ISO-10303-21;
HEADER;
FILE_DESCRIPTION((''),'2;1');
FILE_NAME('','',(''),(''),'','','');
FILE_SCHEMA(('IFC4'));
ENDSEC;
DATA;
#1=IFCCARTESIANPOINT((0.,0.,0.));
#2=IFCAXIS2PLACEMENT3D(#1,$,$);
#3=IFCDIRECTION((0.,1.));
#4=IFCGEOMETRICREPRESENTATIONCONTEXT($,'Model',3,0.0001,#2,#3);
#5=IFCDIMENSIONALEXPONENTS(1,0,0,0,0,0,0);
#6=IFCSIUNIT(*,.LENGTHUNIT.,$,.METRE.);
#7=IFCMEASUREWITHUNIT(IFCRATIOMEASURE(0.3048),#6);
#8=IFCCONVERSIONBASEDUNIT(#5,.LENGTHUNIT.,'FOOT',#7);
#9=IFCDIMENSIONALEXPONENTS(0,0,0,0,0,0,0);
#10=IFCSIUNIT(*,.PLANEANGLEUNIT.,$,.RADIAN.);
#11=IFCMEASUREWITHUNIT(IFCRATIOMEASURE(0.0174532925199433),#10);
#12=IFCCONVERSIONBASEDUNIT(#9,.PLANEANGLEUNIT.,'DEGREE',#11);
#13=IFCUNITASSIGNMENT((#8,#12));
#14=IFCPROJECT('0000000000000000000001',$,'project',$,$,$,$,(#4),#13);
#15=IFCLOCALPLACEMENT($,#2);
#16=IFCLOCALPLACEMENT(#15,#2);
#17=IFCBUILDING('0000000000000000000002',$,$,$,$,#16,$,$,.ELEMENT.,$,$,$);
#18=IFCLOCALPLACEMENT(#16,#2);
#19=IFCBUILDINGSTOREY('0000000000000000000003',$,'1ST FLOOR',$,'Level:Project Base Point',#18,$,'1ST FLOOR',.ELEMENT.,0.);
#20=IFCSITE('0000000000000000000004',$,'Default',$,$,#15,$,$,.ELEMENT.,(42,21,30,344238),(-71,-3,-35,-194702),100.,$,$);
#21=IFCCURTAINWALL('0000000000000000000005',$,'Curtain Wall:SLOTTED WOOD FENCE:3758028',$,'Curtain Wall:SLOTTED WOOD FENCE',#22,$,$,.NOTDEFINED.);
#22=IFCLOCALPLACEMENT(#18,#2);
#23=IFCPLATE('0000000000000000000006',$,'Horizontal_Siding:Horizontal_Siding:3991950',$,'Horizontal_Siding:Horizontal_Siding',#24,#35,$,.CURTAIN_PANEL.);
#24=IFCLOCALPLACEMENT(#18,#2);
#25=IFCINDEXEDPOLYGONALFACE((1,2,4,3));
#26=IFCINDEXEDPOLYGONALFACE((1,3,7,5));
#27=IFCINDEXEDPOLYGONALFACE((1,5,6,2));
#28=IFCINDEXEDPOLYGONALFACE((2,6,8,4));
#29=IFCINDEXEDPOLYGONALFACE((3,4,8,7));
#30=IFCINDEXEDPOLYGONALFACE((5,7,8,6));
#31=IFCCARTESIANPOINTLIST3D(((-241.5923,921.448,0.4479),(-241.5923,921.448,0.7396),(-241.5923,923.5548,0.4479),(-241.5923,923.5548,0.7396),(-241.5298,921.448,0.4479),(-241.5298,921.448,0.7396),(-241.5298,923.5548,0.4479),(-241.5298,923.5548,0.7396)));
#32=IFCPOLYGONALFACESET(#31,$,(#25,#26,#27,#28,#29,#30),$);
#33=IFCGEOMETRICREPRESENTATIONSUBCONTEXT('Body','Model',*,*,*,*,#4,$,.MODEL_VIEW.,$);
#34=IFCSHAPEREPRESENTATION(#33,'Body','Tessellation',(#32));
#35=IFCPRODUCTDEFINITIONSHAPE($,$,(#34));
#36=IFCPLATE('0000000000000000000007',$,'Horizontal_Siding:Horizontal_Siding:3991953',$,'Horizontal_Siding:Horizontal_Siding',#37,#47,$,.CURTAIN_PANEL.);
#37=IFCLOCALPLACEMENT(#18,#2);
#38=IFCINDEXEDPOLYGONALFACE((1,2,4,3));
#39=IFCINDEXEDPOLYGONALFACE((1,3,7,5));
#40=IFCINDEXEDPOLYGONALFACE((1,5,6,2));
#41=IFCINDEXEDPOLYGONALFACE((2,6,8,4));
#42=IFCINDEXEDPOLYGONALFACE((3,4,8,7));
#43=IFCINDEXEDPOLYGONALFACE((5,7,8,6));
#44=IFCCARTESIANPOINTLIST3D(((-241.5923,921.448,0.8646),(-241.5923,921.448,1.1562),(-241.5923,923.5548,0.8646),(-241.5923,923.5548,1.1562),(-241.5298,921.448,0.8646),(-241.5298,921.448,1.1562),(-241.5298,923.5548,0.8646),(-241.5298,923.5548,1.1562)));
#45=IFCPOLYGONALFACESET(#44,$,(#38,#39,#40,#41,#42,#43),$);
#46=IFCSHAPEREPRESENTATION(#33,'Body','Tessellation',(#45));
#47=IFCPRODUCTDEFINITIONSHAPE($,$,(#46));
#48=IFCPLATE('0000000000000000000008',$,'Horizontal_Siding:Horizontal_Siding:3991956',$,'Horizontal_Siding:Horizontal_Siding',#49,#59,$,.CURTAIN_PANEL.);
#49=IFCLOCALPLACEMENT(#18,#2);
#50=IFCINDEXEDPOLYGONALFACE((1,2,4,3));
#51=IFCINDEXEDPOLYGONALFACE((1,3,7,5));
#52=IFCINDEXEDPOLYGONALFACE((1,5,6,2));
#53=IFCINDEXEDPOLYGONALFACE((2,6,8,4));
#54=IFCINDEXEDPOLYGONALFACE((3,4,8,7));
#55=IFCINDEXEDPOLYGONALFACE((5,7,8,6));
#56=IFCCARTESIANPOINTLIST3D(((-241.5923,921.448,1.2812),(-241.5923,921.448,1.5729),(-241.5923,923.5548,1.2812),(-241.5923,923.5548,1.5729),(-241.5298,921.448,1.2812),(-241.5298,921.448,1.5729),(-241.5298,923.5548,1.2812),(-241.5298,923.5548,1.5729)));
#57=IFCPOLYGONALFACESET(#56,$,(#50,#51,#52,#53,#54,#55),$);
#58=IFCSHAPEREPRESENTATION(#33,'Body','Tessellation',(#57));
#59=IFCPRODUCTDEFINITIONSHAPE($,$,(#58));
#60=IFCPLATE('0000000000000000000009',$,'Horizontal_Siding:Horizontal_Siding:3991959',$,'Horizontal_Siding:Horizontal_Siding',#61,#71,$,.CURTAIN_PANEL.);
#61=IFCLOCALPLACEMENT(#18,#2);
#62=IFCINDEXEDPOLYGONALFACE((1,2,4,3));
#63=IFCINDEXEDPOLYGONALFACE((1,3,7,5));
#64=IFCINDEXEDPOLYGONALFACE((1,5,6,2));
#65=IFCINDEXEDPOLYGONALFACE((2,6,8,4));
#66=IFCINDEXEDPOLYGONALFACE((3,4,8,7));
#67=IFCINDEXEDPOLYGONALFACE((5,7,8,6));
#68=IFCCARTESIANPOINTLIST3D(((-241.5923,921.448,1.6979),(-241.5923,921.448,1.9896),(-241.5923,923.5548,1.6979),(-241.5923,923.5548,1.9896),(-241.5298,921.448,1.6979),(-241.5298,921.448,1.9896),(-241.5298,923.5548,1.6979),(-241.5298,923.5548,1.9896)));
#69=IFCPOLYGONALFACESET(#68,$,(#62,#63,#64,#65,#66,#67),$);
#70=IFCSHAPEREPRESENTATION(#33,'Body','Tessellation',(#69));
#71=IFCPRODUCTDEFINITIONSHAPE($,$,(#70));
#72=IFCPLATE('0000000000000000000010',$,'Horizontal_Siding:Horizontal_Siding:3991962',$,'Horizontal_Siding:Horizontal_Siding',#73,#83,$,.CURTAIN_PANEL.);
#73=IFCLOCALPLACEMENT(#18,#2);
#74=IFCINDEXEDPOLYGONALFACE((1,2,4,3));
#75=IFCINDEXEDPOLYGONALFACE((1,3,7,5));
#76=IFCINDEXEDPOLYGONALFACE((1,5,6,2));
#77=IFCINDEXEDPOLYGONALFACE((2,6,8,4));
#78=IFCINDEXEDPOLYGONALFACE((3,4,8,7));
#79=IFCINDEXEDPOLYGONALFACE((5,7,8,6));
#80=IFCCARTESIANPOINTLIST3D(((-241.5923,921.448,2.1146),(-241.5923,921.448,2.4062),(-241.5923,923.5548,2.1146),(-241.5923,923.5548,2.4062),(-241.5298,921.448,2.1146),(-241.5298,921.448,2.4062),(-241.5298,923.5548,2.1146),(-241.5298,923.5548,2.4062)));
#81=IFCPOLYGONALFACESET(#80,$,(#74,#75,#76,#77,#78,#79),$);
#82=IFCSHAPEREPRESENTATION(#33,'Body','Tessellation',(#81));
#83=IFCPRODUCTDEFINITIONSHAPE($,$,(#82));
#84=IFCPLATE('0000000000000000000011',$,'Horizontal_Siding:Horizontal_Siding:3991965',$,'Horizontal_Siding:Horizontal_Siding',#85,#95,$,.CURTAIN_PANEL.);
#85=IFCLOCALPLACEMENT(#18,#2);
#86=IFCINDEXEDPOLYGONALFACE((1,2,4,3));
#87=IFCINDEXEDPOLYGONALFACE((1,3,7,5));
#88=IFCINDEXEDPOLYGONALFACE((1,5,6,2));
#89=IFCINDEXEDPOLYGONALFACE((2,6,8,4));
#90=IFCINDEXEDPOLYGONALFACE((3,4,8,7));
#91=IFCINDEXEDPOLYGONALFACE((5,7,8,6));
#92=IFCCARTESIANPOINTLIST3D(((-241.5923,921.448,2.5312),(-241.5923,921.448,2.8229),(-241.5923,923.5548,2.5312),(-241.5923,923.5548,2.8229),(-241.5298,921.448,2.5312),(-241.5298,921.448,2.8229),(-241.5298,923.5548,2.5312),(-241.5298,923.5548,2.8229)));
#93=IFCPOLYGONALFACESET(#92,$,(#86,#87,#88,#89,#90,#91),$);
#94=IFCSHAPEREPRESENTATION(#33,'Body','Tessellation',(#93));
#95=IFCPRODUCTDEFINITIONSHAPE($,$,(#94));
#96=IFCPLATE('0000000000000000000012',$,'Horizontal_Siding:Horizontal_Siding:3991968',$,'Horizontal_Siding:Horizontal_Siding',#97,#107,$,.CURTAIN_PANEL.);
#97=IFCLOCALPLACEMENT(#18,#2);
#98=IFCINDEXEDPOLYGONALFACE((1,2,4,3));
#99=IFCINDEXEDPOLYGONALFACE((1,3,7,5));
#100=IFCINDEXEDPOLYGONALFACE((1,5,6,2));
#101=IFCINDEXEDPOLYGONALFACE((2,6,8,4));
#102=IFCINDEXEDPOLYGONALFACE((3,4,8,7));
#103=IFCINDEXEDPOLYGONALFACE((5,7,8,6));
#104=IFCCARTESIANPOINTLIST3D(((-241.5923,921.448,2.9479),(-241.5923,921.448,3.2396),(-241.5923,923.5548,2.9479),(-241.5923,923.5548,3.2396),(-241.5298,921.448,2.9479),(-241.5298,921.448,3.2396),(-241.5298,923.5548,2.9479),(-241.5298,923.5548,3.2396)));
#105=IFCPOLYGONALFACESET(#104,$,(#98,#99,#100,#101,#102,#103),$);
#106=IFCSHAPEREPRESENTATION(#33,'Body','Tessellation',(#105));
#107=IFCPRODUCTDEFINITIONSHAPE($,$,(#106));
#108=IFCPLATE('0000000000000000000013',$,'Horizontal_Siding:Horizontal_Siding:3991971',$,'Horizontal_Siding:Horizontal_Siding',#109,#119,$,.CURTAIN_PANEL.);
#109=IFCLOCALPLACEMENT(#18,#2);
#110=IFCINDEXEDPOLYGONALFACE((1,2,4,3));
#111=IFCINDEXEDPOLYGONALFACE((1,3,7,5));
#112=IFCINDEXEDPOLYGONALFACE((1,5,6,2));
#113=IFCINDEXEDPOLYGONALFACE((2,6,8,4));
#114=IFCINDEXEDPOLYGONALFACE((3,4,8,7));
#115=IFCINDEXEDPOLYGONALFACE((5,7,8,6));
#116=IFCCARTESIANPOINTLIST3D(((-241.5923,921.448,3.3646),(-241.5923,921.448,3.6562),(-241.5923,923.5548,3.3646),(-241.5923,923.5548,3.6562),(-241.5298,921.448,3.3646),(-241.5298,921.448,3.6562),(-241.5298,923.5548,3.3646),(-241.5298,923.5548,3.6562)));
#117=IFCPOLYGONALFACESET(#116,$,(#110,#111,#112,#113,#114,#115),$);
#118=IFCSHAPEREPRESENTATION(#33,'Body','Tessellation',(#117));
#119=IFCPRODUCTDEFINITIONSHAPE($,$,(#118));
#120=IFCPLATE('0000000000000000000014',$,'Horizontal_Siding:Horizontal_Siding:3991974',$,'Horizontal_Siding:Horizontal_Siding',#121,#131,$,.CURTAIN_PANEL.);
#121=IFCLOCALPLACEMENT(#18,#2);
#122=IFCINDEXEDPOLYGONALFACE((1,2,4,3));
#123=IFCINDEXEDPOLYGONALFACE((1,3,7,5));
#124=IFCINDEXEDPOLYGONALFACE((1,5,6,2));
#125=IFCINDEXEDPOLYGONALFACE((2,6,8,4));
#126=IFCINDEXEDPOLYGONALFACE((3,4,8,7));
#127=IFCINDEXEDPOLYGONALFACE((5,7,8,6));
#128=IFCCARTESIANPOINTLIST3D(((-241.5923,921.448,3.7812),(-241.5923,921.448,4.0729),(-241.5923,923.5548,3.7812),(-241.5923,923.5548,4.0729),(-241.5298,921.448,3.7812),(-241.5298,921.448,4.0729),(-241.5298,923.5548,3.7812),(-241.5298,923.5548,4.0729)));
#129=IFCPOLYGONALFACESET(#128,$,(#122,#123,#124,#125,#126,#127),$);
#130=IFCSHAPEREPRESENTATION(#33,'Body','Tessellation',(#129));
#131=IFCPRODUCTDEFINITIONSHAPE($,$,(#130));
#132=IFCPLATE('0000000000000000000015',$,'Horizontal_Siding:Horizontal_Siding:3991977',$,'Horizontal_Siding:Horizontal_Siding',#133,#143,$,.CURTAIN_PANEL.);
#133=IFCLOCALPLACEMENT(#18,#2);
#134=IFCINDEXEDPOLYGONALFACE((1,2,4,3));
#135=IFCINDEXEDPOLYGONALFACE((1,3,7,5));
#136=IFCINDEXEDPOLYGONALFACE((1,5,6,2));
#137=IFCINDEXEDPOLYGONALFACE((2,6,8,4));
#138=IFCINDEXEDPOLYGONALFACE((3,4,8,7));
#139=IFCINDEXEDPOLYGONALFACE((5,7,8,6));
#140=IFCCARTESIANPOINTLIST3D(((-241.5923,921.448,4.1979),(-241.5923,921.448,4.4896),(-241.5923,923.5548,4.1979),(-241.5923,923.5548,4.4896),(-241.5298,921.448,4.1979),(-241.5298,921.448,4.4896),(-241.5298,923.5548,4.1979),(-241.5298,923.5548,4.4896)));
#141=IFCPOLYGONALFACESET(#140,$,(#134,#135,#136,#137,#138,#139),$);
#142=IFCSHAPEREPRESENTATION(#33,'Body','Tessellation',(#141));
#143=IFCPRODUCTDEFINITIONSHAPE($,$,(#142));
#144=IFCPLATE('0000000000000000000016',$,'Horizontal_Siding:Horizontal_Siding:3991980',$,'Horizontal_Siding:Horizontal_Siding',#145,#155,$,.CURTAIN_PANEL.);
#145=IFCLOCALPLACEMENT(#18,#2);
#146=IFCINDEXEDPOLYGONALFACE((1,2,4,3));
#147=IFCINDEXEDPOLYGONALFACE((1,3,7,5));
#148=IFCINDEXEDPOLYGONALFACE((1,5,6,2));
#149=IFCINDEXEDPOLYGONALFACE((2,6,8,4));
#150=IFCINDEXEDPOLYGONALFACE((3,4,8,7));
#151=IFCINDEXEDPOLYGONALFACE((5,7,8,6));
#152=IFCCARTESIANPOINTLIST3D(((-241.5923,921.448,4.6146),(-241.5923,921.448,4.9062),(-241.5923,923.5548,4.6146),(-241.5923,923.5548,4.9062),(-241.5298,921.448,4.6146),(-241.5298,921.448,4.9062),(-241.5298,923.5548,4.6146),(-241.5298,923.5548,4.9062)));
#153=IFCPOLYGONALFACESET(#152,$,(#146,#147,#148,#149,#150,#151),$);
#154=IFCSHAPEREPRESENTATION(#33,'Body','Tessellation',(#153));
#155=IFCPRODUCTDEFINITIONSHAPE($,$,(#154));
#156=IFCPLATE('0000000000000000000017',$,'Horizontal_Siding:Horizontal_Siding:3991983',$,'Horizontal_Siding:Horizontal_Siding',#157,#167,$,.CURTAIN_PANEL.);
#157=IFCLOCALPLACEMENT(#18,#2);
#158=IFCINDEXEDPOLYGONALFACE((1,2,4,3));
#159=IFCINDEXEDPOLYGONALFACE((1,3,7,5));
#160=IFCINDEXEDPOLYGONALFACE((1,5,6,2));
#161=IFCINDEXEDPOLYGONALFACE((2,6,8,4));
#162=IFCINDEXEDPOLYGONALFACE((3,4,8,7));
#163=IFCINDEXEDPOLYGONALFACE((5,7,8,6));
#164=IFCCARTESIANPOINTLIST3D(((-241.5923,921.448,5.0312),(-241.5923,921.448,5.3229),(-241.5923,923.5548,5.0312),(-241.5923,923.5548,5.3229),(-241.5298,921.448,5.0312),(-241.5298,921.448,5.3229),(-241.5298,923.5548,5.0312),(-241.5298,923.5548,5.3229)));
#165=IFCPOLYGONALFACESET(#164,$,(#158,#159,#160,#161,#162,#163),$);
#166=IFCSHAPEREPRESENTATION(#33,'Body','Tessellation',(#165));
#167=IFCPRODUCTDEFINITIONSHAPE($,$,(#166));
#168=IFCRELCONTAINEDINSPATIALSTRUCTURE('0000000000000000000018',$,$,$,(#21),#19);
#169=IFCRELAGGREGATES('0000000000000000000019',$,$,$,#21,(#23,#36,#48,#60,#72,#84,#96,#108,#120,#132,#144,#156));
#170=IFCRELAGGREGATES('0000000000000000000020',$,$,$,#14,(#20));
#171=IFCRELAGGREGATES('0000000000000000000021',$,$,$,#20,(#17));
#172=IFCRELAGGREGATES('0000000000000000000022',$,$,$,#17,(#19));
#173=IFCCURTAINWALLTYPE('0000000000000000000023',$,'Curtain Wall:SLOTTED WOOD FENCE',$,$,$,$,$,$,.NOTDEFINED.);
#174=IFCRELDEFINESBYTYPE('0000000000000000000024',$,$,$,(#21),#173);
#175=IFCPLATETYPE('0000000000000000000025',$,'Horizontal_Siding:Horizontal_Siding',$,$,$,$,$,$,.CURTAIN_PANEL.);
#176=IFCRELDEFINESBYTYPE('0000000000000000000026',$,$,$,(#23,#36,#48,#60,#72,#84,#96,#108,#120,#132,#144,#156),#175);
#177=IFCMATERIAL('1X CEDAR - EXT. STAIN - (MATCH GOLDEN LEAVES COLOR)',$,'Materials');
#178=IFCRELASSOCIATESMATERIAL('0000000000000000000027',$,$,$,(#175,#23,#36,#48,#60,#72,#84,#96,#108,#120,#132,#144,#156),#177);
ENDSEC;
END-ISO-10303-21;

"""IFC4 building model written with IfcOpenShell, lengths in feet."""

from ifc_helpers import new_model, entity, si_unit, converted_unit, direction, frame, origin, origin_2d_with_axis, place, context, subcontext, project, spatial, rectangle, extrude, source, transform, mapped, material, type_object, type_shapes, element, aggregate, save


model = new_model("IFC4")

# Units and contexts
model_context = context("Model", 3, precision=0.0001, world=origin(), true_north=direction((0.0, 1.0)))
body_context = subcontext(model_context, "Body", "Model", "MODEL_VIEW")
ifc_project = project(units=[converted_unit("LENGTHUNIT", "FOOT", entity("IfcRatioMeasure", 0.3048), si_unit("LENGTHUNIT", "METRE"), dimensions=[1, 0, 0, 0, 0, 0, 0]), converted_unit("PLANEANGLEUNIT", "DEGREE", entity("IfcRatioMeasure", 0.0174532925199433), si_unit("PLANEANGLEUNIT", "RADIAN"), dimensions=[0, 0, 0, 0, 0, 0, 0])], contexts=[model_context])

# Site, building, storey
site_placement = place(None, origin())
site = spatial("IfcSite", under=ifc_project, at=site_placement, Name="Default", CompositionType="ELEMENT", RefLatitude=(42, 21, 30, 344238), RefLongitude=(-71, -3, -35, -194702), RefElevation=100.0)
building_placement = place(site_placement, origin())
building = spatial("IfcBuilding", under=site, at=building_placement, CompositionType="ELEMENT")
storey_placement = place(building_placement, origin())
storey = spatial("IfcBuildingStorey", under=building, at=storey_placement, Name="1ST FLOOR", ObjectType="Level:Project Base Point", LongName="1ST FLOOR", CompositionType="ELEMENT", Elevation=0.0)

# Curtain wall, plates
curtain_wall_type = type_object("IfcCurtainWallType", Name="Curtain Wall:SLOTTED WOOD FENCE", PredefinedType="NOTDEFINED")
curtain_wall_placement = place(storey_placement, origin())
curtain_wall = element("IfcCurtainWall", 1, at=curtain_wall_placement, inside=storey, type_object=curtain_wall_type, Name="Curtain Wall:SLOTTED WOOD FENCE:3758028", ObjectType="Curtain Wall:SLOTTED WOOD FENCE", PredefinedType="NOTDEFINED")
ifc_material_1 = material(Name="1X CEDAR - EXT. STAIN - (MATCH GOLDEN LEAVES COLOR)", Category="Materials")
plate_type_1 = type_object("IfcPlateType", Name="Horizontal_Siding:Horizontal_Siding", PredefinedType="CURTAIN_PANEL", material=ifc_material_1)
shared_shape_1 = source(origin(), body_context, "Body", "SweptSolid", [
    extrude(rectangle(XDim=0.0625, YDim=2.1069, at=origin_2d_with_axis()), frame((1.0534, 0.0312, 0.0), z_axis=(0.0, 0.0, 1.0), x_axis=(0.0, 1.0, 0.0)), (0.0, 0.0, 1.0), 0.2917),
])
type_shapes(plate_type_1, [shared_shape_1])
plate_1_placement = place(curtain_wall_placement, frame((-241.5923, 923.5548, 0.4479), z_axis=(0.0, 0.0, 1.0), x_axis=(0.0, -1.0, 0.0)))
plate_1 = element("IfcPlate", 2, at=plate_1_placement, type_object=plate_type_1, material=ifc_material_1, Name="Horizontal_Siding:Horizontal_Siding:3991950", ObjectType="Horizontal_Siding:Horizontal_Siding", PredefinedType="CURTAIN_PANEL", context=body_context, shape_type="MappedRepresentation", body=[
    mapped(shared_shape_1, transform((0.0, 0.0, 0.0), scale=1.0)),
])
plate_2_placement = place(curtain_wall_placement, frame((-241.5923, 923.5548, 0.8646), z_axis=(0.0, 0.0, 1.0), x_axis=(0.0, -1.0, 0.0)))
plate_2 = element("IfcPlate", 3, at=plate_2_placement, type_object=plate_type_1, material=ifc_material_1, Name="Horizontal_Siding:Horizontal_Siding:3991953", ObjectType="Horizontal_Siding:Horizontal_Siding", PredefinedType="CURTAIN_PANEL", context=body_context, shape_type="MappedRepresentation", body=[
    mapped(shared_shape_1, transform((0.0, 0.0, 0.0), scale=1.0)),
])
plate_3_placement = place(curtain_wall_placement, frame((-241.5923, 923.5548, 1.2812), z_axis=(0.0, 0.0, 1.0), x_axis=(0.0, -1.0, 0.0)))
plate_3 = element("IfcPlate", 4, at=plate_3_placement, type_object=plate_type_1, material=ifc_material_1, Name="Horizontal_Siding:Horizontal_Siding:3991956", ObjectType="Horizontal_Siding:Horizontal_Siding", PredefinedType="CURTAIN_PANEL", context=body_context, shape_type="MappedRepresentation", body=[
    mapped(shared_shape_1, transform((0.0, 0.0, 0.0), scale=1.0)),
])
plate_4_placement = place(curtain_wall_placement, frame((-241.5923, 923.5548, 1.6979), z_axis=(0.0, 0.0, 1.0), x_axis=(0.0, -1.0, 0.0)))
plate_4 = element("IfcPlate", 5, at=plate_4_placement, type_object=plate_type_1, material=ifc_material_1, Name="Horizontal_Siding:Horizontal_Siding:3991959", ObjectType="Horizontal_Siding:Horizontal_Siding", PredefinedType="CURTAIN_PANEL", context=body_context, shape_type="MappedRepresentation", body=[
    mapped(shared_shape_1, transform((0.0, 0.0, 0.0), scale=1.0)),
])
plate_5_placement = place(curtain_wall_placement, frame((-241.5923, 923.5548, 2.1146), z_axis=(0.0, 0.0, 1.0), x_axis=(0.0, -1.0, 0.0)))
plate_5 = element("IfcPlate", 6, at=plate_5_placement, type_object=plate_type_1, material=ifc_material_1, Name="Horizontal_Siding:Horizontal_Siding:3991962", ObjectType="Horizontal_Siding:Horizontal_Siding", PredefinedType="CURTAIN_PANEL", context=body_context, shape_type="MappedRepresentation", body=[
    mapped(shared_shape_1, transform((0.0, 0.0, 0.0), scale=1.0)),
])
plate_6_placement = place(curtain_wall_placement, frame((-241.5923, 923.5548, 2.5312), z_axis=(0.0, 0.0, 1.0), x_axis=(0.0, -1.0, 0.0)))
plate_6 = element("IfcPlate", 7, at=plate_6_placement, type_object=plate_type_1, material=ifc_material_1, Name="Horizontal_Siding:Horizontal_Siding:3991965", ObjectType="Horizontal_Siding:Horizontal_Siding", PredefinedType="CURTAIN_PANEL", context=body_context, shape_type="MappedRepresentation", body=[
    mapped(shared_shape_1, transform((0.0, 0.0, 0.0), scale=1.0)),
])
plate_7_placement = place(curtain_wall_placement, frame((-241.5923, 923.5548, 2.9479), z_axis=(0.0, 0.0, 1.0), x_axis=(0.0, -1.0, 0.0)))
plate_7 = element("IfcPlate", 8, at=plate_7_placement, type_object=plate_type_1, material=ifc_material_1, Name="Horizontal_Siding:Horizontal_Siding:3991968", ObjectType="Horizontal_Siding:Horizontal_Siding", PredefinedType="CURTAIN_PANEL", context=body_context, shape_type="MappedRepresentation", body=[
    mapped(shared_shape_1, transform((0.0, 0.0, 0.0), scale=1.0)),
])
plate_8_placement = place(curtain_wall_placement, frame((-241.5923, 923.5548, 3.3646), z_axis=(0.0, 0.0, 1.0), x_axis=(0.0, -1.0, 0.0)))
plate_8 = element("IfcPlate", 9, at=plate_8_placement, type_object=plate_type_1, material=ifc_material_1, Name="Horizontal_Siding:Horizontal_Siding:3991971", ObjectType="Horizontal_Siding:Horizontal_Siding", PredefinedType="CURTAIN_PANEL", context=body_context, shape_type="MappedRepresentation", body=[
    mapped(shared_shape_1, transform((0.0, 0.0, 0.0), scale=1.0)),
])
plate_9_placement = place(curtain_wall_placement, frame((-241.5923, 923.5548, 3.7812), z_axis=(0.0, 0.0, 1.0), x_axis=(0.0, -1.0, 0.0)))
plate_9 = element("IfcPlate", 10, at=plate_9_placement, type_object=plate_type_1, material=ifc_material_1, Name="Horizontal_Siding:Horizontal_Siding:3991974", ObjectType="Horizontal_Siding:Horizontal_Siding", PredefinedType="CURTAIN_PANEL", context=body_context, shape_type="MappedRepresentation", body=[
    mapped(shared_shape_1, transform((0.0, 0.0, 0.0), scale=1.0)),
])
plate_10_placement = place(curtain_wall_placement, frame((-241.5923, 923.5548, 4.1979), z_axis=(0.0, 0.0, 1.0), x_axis=(0.0, -1.0, 0.0)))
plate_10 = element("IfcPlate", 11, at=plate_10_placement, type_object=plate_type_1, material=ifc_material_1, Name="Horizontal_Siding:Horizontal_Siding:3991977", ObjectType="Horizontal_Siding:Horizontal_Siding", PredefinedType="CURTAIN_PANEL", context=body_context, shape_type="MappedRepresentation", body=[
    mapped(shared_shape_1, transform((0.0, 0.0, 0.0), scale=1.0)),
])
plate_11_placement = place(curtain_wall_placement, frame((-241.5923, 923.5548, 4.6146), z_axis=(0.0, 0.0, 1.0), x_axis=(0.0, -1.0, 0.0)))
plate_11 = element("IfcPlate", 12, at=plate_11_placement, type_object=plate_type_1, material=ifc_material_1, Name="Horizontal_Siding:Horizontal_Siding:3991980", ObjectType="Horizontal_Siding:Horizontal_Siding", PredefinedType="CURTAIN_PANEL", context=body_context, shape_type="MappedRepresentation", body=[
    mapped(shared_shape_1, transform((0.0, 0.0, 0.0), scale=1.0)),
])
plate_12_placement = place(curtain_wall_placement, frame((-241.5923, 923.5548, 5.0312), z_axis=(0.0, 0.0, 1.0), x_axis=(0.0, -1.0, 0.0)))
plate_12 = element("IfcPlate", 13, at=plate_12_placement, type_object=plate_type_1, material=ifc_material_1, Name="Horizontal_Siding:Horizontal_Siding:3991983", ObjectType="Horizontal_Siding:Horizontal_Siding", PredefinedType="CURTAIN_PANEL", context=body_context, shape_type="MappedRepresentation", body=[
    mapped(shared_shape_1, transform((0.0, 0.0, 0.0), scale=1.0)),
])
aggregate(curtain_wall, [plate_1, plate_2, plate_3, plate_4, plate_5, plate_6, plate_7, plate_8, plate_9, plate_10, plate_11, plate_12])

save(model, "model.ifc")
